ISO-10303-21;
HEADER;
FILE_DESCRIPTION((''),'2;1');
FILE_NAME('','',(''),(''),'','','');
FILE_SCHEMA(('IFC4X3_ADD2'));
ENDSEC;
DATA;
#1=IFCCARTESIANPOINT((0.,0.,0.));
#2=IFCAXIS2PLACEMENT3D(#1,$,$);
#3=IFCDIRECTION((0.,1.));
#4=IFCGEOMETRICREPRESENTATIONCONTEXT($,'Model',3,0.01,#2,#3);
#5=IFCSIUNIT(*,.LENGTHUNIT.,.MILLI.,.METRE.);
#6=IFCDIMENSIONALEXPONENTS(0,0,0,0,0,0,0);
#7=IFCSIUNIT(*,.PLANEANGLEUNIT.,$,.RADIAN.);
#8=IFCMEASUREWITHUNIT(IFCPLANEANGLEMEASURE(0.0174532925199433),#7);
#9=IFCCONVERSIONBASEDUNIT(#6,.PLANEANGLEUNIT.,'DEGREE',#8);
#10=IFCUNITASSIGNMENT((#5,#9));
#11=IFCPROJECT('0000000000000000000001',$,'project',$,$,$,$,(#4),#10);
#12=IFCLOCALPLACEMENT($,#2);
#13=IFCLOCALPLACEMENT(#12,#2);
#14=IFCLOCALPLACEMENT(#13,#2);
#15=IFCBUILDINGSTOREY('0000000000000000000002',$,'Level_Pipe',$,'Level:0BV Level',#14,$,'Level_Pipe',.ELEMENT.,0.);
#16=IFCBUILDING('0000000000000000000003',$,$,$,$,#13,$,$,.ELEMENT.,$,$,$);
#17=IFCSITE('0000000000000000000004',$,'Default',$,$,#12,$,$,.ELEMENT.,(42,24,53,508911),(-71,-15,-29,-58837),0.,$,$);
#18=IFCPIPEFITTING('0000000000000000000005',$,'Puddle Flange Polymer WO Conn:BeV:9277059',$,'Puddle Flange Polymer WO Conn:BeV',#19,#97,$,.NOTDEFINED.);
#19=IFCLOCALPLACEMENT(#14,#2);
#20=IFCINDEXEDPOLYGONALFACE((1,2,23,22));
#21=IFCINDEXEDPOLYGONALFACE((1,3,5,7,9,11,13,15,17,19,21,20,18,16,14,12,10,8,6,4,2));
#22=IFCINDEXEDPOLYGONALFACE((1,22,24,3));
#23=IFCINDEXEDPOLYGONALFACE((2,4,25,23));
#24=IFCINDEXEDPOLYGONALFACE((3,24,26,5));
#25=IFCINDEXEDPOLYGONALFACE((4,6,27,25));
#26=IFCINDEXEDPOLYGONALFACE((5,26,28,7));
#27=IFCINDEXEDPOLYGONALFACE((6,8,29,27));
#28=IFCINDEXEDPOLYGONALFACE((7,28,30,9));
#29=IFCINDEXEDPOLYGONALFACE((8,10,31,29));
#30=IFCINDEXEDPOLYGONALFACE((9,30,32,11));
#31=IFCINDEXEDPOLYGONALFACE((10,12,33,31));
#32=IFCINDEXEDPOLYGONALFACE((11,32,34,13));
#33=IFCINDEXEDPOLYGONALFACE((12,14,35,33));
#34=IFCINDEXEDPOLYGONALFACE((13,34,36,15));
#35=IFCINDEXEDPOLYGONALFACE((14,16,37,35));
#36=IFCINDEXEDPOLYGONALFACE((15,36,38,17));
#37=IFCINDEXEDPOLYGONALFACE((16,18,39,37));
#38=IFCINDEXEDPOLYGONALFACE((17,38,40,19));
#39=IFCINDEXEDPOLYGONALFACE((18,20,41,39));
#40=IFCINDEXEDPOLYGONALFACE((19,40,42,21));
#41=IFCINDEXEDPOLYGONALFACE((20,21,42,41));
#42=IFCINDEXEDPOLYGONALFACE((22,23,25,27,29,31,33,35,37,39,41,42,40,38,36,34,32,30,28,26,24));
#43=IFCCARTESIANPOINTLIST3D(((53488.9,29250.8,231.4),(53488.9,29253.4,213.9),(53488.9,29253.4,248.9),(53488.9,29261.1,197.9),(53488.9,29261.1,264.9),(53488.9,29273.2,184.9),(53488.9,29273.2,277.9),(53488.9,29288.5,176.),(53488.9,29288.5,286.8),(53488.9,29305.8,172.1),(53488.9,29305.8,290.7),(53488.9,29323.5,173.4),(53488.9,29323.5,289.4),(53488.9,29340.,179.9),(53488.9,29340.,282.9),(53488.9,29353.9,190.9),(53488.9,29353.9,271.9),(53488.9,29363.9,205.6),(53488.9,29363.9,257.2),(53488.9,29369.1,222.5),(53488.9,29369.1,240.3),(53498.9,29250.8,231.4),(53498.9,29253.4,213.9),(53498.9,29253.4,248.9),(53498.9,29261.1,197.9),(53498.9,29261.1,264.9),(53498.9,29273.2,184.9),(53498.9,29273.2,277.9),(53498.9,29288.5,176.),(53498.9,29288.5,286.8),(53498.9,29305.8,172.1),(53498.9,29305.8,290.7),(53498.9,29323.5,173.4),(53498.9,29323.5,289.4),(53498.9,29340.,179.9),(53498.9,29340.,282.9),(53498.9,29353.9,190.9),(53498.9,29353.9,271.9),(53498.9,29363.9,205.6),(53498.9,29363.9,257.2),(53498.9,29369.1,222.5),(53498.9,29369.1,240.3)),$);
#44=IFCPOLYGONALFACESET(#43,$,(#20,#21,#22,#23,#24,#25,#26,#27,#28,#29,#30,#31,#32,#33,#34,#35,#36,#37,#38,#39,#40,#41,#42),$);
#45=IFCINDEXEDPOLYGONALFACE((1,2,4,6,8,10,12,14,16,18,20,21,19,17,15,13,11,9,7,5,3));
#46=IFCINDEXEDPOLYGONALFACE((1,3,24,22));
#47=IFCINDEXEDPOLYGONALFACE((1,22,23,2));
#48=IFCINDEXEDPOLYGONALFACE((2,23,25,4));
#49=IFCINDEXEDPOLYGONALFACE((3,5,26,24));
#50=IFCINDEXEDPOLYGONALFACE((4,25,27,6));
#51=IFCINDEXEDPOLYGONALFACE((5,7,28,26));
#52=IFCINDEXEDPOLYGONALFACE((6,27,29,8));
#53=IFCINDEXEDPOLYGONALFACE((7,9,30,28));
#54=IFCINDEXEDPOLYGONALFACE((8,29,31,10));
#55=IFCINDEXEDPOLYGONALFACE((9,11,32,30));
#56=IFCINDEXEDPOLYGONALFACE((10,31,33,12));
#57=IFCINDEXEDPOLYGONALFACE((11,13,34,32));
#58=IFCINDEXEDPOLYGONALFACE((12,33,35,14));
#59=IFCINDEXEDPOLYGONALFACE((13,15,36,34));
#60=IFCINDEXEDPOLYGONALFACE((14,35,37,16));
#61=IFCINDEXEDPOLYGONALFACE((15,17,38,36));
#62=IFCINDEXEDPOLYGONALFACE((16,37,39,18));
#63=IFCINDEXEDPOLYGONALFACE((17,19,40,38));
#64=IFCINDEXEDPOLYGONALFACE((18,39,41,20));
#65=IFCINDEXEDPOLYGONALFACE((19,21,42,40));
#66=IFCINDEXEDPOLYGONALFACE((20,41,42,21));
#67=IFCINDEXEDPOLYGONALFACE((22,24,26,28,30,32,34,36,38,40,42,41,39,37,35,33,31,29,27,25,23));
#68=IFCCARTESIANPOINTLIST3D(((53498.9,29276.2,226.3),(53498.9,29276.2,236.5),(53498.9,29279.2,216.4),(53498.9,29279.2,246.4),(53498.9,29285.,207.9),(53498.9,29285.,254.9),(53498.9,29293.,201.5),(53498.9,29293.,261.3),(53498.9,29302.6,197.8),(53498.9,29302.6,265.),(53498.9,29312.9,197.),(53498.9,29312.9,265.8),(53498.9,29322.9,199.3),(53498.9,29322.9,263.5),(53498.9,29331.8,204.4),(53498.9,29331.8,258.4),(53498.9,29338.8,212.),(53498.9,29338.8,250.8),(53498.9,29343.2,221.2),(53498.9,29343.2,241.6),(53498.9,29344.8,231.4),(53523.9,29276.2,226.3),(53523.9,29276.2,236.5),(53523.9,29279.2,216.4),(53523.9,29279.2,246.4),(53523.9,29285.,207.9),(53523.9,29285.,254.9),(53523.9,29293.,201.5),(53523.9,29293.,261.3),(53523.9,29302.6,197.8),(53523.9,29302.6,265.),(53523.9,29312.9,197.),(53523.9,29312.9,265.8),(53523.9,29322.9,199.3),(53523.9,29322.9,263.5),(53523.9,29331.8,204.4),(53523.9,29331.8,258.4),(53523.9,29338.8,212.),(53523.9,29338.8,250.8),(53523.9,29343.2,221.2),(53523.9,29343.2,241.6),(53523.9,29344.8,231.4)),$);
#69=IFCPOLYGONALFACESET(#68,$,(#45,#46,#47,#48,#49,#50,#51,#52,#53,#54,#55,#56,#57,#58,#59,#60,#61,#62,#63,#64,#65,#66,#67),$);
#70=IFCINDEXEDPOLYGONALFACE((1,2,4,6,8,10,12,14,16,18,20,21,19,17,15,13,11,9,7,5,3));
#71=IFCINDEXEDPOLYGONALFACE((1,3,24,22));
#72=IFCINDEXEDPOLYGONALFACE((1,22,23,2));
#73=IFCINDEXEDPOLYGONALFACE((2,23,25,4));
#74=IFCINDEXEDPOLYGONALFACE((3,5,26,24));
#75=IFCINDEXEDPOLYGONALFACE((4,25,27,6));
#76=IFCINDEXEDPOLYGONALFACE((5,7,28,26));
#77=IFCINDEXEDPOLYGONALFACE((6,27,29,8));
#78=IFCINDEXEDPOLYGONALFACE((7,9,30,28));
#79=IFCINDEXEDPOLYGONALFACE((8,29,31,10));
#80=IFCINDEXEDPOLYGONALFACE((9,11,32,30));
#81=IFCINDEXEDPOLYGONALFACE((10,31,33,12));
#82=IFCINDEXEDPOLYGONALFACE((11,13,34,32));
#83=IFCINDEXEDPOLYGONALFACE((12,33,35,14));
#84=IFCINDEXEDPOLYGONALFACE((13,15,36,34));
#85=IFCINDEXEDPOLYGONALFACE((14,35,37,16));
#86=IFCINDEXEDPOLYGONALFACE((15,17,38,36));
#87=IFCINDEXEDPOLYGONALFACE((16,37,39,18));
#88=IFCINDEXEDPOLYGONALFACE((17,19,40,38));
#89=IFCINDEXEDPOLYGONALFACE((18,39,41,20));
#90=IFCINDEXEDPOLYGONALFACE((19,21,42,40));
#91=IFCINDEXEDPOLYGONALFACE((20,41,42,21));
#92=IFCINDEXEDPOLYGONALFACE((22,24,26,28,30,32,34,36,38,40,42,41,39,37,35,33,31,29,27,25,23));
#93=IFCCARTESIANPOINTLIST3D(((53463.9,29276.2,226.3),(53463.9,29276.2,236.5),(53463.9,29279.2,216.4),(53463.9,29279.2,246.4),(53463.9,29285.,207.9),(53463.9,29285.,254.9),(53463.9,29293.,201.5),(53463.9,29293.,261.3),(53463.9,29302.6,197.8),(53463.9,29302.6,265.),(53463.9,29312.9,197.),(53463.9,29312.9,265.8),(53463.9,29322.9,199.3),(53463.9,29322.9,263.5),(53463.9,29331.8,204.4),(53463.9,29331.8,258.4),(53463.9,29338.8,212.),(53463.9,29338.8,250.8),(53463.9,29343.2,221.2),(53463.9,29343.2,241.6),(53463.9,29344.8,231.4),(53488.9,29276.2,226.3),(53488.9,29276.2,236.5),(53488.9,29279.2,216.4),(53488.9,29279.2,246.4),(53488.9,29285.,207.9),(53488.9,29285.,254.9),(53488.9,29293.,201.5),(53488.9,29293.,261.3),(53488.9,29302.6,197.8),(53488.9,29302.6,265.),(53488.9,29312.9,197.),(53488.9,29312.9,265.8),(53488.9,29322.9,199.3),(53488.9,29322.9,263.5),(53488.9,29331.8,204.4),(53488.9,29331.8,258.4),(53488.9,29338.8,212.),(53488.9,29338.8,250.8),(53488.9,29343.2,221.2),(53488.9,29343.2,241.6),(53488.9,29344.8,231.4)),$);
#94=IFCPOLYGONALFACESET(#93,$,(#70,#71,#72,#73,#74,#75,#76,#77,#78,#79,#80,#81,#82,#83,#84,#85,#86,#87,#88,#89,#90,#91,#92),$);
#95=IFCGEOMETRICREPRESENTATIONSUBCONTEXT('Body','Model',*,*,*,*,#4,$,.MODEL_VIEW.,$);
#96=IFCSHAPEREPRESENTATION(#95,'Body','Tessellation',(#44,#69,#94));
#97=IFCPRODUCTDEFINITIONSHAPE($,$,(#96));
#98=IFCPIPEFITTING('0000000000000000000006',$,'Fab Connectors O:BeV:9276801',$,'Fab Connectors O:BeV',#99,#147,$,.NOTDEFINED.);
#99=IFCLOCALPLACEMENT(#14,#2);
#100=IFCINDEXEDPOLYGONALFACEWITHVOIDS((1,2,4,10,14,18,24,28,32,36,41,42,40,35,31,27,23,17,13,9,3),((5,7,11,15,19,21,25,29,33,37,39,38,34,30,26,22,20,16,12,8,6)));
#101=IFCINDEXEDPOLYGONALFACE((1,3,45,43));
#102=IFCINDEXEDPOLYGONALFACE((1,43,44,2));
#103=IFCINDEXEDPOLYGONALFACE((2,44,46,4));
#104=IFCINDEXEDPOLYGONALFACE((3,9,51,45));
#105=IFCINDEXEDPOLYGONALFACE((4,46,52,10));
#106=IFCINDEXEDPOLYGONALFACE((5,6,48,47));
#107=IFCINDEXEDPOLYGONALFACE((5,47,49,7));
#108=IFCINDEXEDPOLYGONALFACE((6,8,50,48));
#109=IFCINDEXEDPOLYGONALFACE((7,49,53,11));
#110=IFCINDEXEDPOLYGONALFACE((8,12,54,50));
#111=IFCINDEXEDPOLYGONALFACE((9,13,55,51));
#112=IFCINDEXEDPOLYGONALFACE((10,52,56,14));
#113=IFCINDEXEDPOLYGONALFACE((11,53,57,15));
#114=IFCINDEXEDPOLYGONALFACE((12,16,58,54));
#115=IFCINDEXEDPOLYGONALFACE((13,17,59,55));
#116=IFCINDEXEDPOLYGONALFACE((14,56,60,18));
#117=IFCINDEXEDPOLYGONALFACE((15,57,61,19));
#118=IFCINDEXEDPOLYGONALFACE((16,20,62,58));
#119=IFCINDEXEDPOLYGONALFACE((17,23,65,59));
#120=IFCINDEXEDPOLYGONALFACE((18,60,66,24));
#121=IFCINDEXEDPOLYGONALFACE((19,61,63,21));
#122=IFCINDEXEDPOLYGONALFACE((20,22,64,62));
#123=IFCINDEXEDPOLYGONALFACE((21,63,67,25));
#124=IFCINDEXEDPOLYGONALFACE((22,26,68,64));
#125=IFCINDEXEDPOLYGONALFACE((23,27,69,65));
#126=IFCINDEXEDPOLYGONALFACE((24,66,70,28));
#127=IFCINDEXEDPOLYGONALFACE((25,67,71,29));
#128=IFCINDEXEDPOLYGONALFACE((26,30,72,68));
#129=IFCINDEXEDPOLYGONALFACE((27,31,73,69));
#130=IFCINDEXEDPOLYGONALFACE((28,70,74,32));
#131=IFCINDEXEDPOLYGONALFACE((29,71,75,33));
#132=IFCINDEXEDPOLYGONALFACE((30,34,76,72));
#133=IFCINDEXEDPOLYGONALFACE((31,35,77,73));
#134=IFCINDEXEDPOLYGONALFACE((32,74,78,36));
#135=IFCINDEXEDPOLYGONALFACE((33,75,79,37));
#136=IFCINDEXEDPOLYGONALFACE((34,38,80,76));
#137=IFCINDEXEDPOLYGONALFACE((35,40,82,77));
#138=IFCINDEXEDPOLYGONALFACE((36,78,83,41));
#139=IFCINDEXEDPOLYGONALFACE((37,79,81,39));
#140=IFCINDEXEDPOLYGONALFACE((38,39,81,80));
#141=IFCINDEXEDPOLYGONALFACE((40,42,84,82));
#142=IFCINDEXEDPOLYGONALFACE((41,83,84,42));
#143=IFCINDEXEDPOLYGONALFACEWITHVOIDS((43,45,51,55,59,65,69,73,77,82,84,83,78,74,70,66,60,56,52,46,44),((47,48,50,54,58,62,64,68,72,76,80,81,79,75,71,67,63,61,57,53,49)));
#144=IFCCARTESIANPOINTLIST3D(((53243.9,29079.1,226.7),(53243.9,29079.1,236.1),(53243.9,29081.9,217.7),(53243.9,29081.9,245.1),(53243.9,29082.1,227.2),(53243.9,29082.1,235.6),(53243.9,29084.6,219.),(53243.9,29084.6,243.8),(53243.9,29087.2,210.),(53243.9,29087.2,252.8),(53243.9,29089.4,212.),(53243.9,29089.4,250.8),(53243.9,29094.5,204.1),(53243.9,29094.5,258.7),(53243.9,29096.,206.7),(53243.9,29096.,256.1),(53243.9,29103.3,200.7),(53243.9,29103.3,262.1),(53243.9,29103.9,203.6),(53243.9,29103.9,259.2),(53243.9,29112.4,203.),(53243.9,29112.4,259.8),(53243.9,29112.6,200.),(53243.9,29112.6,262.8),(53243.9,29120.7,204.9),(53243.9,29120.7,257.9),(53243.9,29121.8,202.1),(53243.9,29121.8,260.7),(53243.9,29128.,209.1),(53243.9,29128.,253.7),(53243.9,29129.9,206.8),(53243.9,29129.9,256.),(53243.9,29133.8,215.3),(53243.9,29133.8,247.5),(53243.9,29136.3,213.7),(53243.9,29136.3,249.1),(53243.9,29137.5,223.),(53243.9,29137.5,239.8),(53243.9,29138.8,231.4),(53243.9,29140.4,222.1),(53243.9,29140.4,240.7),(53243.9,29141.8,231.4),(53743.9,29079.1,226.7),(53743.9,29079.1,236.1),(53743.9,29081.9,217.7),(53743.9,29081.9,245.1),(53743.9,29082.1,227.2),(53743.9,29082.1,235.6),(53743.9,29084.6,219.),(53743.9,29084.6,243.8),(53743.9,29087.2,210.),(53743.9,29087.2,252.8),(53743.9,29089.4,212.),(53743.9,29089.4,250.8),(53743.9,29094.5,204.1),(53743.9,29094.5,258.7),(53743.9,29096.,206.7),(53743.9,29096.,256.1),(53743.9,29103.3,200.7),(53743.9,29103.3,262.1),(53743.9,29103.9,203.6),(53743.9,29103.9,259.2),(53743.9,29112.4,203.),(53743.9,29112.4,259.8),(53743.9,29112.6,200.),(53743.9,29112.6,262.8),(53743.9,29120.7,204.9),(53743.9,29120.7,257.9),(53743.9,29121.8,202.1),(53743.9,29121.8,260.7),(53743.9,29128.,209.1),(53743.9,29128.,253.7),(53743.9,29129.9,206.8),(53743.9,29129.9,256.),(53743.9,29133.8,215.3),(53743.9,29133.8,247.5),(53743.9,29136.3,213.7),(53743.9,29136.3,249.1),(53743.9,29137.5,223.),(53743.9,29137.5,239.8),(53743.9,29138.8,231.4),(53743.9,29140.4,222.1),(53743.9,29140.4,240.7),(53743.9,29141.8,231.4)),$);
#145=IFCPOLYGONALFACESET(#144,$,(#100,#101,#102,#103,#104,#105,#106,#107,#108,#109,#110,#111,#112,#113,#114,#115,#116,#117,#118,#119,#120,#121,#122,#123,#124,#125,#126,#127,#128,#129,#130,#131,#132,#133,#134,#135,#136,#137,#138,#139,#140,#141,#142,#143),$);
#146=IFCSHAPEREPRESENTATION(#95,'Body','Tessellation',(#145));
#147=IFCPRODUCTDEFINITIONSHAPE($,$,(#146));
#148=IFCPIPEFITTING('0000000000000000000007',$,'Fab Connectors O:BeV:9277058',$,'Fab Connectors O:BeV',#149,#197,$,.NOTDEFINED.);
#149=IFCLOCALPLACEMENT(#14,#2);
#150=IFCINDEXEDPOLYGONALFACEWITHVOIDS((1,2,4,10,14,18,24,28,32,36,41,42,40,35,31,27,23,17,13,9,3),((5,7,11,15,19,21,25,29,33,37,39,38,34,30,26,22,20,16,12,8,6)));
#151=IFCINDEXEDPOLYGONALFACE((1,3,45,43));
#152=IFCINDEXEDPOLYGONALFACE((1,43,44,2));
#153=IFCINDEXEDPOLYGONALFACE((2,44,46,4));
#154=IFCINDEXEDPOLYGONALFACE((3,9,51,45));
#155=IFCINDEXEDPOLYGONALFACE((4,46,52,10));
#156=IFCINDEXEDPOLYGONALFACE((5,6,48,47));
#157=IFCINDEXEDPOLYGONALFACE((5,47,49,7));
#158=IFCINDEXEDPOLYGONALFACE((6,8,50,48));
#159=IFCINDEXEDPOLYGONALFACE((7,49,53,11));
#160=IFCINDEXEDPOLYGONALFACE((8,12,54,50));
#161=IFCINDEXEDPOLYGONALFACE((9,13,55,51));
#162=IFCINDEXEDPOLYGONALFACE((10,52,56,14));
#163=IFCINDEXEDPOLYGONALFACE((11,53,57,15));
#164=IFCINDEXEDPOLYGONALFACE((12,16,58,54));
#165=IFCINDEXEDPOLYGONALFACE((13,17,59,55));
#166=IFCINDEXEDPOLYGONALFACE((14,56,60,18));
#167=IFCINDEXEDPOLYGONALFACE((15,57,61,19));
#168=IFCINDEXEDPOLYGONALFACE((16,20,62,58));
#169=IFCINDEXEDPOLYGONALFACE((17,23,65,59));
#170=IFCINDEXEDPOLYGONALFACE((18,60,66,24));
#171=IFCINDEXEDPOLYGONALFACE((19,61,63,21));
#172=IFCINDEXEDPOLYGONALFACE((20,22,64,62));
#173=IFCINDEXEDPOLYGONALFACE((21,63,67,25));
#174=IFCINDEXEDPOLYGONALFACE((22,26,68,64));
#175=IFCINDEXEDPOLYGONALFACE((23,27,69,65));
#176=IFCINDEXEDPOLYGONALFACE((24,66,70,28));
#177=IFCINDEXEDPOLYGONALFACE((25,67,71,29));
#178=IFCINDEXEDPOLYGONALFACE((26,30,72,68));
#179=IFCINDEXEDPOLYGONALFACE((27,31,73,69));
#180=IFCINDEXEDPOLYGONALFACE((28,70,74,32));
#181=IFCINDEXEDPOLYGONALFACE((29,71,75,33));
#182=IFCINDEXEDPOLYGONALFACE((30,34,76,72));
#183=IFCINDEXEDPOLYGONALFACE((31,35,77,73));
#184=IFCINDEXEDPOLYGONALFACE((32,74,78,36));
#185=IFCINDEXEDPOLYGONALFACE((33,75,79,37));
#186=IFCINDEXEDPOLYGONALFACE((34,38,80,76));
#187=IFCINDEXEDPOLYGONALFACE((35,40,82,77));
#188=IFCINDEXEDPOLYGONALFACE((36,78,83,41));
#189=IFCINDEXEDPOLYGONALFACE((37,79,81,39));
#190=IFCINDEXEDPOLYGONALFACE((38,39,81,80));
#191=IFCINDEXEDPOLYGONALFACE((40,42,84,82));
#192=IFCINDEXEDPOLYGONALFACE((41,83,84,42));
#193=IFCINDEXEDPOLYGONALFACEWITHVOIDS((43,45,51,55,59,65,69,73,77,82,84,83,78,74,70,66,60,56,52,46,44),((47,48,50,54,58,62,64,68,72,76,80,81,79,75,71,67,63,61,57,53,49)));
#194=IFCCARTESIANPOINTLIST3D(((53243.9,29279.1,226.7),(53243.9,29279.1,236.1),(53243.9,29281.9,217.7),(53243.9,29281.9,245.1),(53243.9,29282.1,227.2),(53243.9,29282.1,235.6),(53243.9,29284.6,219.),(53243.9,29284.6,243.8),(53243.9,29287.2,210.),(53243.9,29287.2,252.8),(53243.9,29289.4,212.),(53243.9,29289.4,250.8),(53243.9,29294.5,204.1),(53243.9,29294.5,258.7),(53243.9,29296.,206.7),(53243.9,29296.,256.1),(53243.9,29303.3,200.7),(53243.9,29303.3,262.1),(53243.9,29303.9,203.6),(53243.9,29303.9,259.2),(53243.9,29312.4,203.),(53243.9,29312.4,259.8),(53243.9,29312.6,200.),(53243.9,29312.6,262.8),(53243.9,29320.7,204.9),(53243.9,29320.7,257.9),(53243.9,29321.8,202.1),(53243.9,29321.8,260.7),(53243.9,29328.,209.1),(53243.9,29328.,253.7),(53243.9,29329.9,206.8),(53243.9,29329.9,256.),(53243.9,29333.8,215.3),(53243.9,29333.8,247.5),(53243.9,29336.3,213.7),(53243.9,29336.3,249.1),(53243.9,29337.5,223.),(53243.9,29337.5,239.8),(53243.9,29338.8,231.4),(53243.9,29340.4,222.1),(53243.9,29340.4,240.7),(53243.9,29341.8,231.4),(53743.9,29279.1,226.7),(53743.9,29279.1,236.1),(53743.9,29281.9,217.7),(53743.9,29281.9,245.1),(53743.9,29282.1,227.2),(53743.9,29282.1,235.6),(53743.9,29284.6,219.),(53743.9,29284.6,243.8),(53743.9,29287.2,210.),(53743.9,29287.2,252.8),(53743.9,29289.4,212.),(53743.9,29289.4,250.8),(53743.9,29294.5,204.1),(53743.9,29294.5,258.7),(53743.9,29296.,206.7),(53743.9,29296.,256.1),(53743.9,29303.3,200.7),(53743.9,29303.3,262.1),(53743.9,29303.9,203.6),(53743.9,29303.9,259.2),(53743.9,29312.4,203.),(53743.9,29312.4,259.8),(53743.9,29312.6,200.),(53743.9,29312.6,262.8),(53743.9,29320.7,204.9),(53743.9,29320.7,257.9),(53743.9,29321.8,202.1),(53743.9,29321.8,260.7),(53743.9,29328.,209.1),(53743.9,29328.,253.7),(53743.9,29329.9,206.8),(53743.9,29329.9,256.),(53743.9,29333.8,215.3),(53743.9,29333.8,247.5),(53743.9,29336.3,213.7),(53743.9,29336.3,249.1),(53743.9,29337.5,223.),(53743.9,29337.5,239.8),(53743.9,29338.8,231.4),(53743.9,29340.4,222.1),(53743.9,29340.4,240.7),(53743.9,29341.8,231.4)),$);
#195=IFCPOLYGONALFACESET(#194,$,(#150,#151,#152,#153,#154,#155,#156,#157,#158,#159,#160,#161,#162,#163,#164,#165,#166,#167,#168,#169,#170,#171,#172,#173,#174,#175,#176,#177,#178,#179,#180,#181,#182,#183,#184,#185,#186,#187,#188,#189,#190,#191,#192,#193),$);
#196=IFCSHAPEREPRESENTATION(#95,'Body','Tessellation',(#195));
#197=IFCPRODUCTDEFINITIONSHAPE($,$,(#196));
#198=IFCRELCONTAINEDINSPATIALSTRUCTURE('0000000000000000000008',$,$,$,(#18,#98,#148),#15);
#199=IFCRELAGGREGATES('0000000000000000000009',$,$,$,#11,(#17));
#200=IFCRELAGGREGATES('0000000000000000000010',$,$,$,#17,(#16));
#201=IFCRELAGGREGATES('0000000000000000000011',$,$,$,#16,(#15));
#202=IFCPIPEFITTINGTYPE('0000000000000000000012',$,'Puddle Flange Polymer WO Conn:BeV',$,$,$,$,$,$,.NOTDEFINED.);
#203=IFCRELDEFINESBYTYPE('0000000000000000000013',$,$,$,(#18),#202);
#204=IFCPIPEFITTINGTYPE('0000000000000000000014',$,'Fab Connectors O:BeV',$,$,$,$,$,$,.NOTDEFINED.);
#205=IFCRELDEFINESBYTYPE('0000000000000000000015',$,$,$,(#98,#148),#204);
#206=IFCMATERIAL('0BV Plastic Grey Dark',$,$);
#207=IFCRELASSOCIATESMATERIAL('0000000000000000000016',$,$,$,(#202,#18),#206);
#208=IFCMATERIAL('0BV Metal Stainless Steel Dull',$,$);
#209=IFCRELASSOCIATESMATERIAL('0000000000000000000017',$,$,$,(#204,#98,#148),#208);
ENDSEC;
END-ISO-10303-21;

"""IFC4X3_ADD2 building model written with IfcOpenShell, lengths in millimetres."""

from ifc_helpers import new_model, entity, si_unit, converted_unit, direction, frame, frame_2d, origin, place, context, subcontext, project, spatial, circle, hollow_circle, extrude, source, transform, mapped, material, type_object, type_shapes, element, save


model = new_model("IFC4X3_ADD2")

# Units and contexts
model_context = context("Model", 3, precision=0.01, world=origin(), true_north=direction((0.0, 1.0)))
body_context = subcontext(model_context, "Body", "Model", "MODEL_VIEW")
ifc_project = project(units=[si_unit("LENGTHUNIT", "METRE", prefix="MILLI"), converted_unit("PLANEANGLEUNIT", "DEGREE", entity("IfcPlaneAngleMeasure", 0.0174532925199433), si_unit("PLANEANGLEUNIT", "RADIAN"), dimensions=[0, 0, 0, 0, 0, 0, 0])], contexts=[model_context])

# Site, building, storey
site_placement = place(None, origin())
site = spatial("IfcSite", under=ifc_project, at=site_placement, Name="Default", CompositionType="ELEMENT", RefLatitude=(42, 24, 53, 508911), RefLongitude=(-71, -15, -29, -58837), RefElevation=0.0)
building_placement = place(site_placement, origin())
building = spatial("IfcBuilding", under=site, at=building_placement, CompositionType="ELEMENT")
storey_placement = place(building_placement, origin())
storey = spatial("IfcBuildingStorey", under=building, at=storey_placement, Name="Level_Pipe", ObjectType="Level:0BV Level", LongName="Level_Pipe", CompositionType="ELEMENT", Elevation=0.0)

# Shared definitions
ifc_material_1 = material(Name="0BV Metal Stainless Steel Dull")

# Pipe fittings
ifc_material_2 = material(Name="0BV Plastic Grey Dark")
pipe_fitting_type_1 = type_object("IfcPipeFittingType", Name="Puddle Flange Polymer WO Conn:BeV", PredefinedType="NOTDEFINED", material=ifc_material_2)
shared_shape_1 = source(origin(), body_context, "Body", "SweptSolid", [
    extrude(circle(Radius=59.5, at=frame_2d((0.0, 0.0), x_axis=(1.0, 0.0))), frame((-5.0, 0.0, 0.0), z_axis=(1.0, 0.0, 0.0), x_axis=(0.0, -1.0, 0.0)), (0.0, 0.0, 1.0), 10.0),
    extrude(circle(Radius=34.5, at=frame_2d((0.0, 0.0), x_axis=(1.0, 0.0))), frame((5.0, 0.0, 0.0), z_axis=(1.0, 0.0, 0.0), x_axis=(0.0, 1.0, 0.0)), (0.0, 0.0, 1.0), 25.0),
    extrude(circle(Radius=34.5, at=frame_2d((0.0, 0.0), x_axis=(1.0, 0.0))), frame((-30.0, 0.0, 0.0), z_axis=(1.0, 0.0, 0.0), x_axis=(0.0, 1.0, 0.0)), (0.0, 0.0, 1.0), 25.0),
])
type_shapes(pipe_fitting_type_1, [shared_shape_1])
for number, where, name in (
    (1, (53493.9, 29310.3, 231.4), "Puddle Flange Polymer WO Conn:BeV:9277059"),
):
    element("IfcPipeFitting", number, at=place(storey_placement, frame(where)), inside=storey, type_object=pipe_fitting_type_1, material=ifc_material_2, Name=name, ObjectType="Puddle Flange Polymer WO Conn:BeV", PredefinedType="NOTDEFINED", context=body_context, shape_type="MappedRepresentation", body=[
        mapped(shared_shape_1, transform((0.0, 0.0, 0.0), scale=1.0)),
    ])
pipe_fitting_type_2 = type_object("IfcPipeFittingType", Name="Fab Connectors O:BeV", PredefinedType="NOTDEFINED", material=ifc_material_1)
shared_shape_2 = source(origin(), body_context, "Body", "SweptSolid", [
    extrude(hollow_circle(Radius=31.5, WallThickness=3.0, at=frame_2d((0.0, 0.0), x_axis=(1.0, 0.0))), frame((0.0, 0.0, 0.0), z_axis=(1.0, 0.0, 0.0), x_axis=(0.0, 1.0, 0.0)), (0.0, 0.0, 1.0), 500.0),
])
type_shapes(pipe_fitting_type_2, [shared_shape_2])
for number, where, name in (
    (2, (53243.9, 29110.3, 231.4), "Fab Connectors O:BeV:9276801"),
    (3, (53243.9, 29310.3, 231.4), "Fab Connectors O:BeV:9277058"),
):
    element("IfcPipeFitting", number, at=place(storey_placement, frame(where)), inside=storey, type_object=pipe_fitting_type_2, material=ifc_material_1, Name=name, ObjectType="Fab Connectors O:BeV", PredefinedType="NOTDEFINED", context=body_context, shape_type="MappedRepresentation", body=[
        mapped(shared_shape_2, transform((0.0, 0.0, 0.0), scale=1.0)),
    ])

save(model, "model.ifc")
